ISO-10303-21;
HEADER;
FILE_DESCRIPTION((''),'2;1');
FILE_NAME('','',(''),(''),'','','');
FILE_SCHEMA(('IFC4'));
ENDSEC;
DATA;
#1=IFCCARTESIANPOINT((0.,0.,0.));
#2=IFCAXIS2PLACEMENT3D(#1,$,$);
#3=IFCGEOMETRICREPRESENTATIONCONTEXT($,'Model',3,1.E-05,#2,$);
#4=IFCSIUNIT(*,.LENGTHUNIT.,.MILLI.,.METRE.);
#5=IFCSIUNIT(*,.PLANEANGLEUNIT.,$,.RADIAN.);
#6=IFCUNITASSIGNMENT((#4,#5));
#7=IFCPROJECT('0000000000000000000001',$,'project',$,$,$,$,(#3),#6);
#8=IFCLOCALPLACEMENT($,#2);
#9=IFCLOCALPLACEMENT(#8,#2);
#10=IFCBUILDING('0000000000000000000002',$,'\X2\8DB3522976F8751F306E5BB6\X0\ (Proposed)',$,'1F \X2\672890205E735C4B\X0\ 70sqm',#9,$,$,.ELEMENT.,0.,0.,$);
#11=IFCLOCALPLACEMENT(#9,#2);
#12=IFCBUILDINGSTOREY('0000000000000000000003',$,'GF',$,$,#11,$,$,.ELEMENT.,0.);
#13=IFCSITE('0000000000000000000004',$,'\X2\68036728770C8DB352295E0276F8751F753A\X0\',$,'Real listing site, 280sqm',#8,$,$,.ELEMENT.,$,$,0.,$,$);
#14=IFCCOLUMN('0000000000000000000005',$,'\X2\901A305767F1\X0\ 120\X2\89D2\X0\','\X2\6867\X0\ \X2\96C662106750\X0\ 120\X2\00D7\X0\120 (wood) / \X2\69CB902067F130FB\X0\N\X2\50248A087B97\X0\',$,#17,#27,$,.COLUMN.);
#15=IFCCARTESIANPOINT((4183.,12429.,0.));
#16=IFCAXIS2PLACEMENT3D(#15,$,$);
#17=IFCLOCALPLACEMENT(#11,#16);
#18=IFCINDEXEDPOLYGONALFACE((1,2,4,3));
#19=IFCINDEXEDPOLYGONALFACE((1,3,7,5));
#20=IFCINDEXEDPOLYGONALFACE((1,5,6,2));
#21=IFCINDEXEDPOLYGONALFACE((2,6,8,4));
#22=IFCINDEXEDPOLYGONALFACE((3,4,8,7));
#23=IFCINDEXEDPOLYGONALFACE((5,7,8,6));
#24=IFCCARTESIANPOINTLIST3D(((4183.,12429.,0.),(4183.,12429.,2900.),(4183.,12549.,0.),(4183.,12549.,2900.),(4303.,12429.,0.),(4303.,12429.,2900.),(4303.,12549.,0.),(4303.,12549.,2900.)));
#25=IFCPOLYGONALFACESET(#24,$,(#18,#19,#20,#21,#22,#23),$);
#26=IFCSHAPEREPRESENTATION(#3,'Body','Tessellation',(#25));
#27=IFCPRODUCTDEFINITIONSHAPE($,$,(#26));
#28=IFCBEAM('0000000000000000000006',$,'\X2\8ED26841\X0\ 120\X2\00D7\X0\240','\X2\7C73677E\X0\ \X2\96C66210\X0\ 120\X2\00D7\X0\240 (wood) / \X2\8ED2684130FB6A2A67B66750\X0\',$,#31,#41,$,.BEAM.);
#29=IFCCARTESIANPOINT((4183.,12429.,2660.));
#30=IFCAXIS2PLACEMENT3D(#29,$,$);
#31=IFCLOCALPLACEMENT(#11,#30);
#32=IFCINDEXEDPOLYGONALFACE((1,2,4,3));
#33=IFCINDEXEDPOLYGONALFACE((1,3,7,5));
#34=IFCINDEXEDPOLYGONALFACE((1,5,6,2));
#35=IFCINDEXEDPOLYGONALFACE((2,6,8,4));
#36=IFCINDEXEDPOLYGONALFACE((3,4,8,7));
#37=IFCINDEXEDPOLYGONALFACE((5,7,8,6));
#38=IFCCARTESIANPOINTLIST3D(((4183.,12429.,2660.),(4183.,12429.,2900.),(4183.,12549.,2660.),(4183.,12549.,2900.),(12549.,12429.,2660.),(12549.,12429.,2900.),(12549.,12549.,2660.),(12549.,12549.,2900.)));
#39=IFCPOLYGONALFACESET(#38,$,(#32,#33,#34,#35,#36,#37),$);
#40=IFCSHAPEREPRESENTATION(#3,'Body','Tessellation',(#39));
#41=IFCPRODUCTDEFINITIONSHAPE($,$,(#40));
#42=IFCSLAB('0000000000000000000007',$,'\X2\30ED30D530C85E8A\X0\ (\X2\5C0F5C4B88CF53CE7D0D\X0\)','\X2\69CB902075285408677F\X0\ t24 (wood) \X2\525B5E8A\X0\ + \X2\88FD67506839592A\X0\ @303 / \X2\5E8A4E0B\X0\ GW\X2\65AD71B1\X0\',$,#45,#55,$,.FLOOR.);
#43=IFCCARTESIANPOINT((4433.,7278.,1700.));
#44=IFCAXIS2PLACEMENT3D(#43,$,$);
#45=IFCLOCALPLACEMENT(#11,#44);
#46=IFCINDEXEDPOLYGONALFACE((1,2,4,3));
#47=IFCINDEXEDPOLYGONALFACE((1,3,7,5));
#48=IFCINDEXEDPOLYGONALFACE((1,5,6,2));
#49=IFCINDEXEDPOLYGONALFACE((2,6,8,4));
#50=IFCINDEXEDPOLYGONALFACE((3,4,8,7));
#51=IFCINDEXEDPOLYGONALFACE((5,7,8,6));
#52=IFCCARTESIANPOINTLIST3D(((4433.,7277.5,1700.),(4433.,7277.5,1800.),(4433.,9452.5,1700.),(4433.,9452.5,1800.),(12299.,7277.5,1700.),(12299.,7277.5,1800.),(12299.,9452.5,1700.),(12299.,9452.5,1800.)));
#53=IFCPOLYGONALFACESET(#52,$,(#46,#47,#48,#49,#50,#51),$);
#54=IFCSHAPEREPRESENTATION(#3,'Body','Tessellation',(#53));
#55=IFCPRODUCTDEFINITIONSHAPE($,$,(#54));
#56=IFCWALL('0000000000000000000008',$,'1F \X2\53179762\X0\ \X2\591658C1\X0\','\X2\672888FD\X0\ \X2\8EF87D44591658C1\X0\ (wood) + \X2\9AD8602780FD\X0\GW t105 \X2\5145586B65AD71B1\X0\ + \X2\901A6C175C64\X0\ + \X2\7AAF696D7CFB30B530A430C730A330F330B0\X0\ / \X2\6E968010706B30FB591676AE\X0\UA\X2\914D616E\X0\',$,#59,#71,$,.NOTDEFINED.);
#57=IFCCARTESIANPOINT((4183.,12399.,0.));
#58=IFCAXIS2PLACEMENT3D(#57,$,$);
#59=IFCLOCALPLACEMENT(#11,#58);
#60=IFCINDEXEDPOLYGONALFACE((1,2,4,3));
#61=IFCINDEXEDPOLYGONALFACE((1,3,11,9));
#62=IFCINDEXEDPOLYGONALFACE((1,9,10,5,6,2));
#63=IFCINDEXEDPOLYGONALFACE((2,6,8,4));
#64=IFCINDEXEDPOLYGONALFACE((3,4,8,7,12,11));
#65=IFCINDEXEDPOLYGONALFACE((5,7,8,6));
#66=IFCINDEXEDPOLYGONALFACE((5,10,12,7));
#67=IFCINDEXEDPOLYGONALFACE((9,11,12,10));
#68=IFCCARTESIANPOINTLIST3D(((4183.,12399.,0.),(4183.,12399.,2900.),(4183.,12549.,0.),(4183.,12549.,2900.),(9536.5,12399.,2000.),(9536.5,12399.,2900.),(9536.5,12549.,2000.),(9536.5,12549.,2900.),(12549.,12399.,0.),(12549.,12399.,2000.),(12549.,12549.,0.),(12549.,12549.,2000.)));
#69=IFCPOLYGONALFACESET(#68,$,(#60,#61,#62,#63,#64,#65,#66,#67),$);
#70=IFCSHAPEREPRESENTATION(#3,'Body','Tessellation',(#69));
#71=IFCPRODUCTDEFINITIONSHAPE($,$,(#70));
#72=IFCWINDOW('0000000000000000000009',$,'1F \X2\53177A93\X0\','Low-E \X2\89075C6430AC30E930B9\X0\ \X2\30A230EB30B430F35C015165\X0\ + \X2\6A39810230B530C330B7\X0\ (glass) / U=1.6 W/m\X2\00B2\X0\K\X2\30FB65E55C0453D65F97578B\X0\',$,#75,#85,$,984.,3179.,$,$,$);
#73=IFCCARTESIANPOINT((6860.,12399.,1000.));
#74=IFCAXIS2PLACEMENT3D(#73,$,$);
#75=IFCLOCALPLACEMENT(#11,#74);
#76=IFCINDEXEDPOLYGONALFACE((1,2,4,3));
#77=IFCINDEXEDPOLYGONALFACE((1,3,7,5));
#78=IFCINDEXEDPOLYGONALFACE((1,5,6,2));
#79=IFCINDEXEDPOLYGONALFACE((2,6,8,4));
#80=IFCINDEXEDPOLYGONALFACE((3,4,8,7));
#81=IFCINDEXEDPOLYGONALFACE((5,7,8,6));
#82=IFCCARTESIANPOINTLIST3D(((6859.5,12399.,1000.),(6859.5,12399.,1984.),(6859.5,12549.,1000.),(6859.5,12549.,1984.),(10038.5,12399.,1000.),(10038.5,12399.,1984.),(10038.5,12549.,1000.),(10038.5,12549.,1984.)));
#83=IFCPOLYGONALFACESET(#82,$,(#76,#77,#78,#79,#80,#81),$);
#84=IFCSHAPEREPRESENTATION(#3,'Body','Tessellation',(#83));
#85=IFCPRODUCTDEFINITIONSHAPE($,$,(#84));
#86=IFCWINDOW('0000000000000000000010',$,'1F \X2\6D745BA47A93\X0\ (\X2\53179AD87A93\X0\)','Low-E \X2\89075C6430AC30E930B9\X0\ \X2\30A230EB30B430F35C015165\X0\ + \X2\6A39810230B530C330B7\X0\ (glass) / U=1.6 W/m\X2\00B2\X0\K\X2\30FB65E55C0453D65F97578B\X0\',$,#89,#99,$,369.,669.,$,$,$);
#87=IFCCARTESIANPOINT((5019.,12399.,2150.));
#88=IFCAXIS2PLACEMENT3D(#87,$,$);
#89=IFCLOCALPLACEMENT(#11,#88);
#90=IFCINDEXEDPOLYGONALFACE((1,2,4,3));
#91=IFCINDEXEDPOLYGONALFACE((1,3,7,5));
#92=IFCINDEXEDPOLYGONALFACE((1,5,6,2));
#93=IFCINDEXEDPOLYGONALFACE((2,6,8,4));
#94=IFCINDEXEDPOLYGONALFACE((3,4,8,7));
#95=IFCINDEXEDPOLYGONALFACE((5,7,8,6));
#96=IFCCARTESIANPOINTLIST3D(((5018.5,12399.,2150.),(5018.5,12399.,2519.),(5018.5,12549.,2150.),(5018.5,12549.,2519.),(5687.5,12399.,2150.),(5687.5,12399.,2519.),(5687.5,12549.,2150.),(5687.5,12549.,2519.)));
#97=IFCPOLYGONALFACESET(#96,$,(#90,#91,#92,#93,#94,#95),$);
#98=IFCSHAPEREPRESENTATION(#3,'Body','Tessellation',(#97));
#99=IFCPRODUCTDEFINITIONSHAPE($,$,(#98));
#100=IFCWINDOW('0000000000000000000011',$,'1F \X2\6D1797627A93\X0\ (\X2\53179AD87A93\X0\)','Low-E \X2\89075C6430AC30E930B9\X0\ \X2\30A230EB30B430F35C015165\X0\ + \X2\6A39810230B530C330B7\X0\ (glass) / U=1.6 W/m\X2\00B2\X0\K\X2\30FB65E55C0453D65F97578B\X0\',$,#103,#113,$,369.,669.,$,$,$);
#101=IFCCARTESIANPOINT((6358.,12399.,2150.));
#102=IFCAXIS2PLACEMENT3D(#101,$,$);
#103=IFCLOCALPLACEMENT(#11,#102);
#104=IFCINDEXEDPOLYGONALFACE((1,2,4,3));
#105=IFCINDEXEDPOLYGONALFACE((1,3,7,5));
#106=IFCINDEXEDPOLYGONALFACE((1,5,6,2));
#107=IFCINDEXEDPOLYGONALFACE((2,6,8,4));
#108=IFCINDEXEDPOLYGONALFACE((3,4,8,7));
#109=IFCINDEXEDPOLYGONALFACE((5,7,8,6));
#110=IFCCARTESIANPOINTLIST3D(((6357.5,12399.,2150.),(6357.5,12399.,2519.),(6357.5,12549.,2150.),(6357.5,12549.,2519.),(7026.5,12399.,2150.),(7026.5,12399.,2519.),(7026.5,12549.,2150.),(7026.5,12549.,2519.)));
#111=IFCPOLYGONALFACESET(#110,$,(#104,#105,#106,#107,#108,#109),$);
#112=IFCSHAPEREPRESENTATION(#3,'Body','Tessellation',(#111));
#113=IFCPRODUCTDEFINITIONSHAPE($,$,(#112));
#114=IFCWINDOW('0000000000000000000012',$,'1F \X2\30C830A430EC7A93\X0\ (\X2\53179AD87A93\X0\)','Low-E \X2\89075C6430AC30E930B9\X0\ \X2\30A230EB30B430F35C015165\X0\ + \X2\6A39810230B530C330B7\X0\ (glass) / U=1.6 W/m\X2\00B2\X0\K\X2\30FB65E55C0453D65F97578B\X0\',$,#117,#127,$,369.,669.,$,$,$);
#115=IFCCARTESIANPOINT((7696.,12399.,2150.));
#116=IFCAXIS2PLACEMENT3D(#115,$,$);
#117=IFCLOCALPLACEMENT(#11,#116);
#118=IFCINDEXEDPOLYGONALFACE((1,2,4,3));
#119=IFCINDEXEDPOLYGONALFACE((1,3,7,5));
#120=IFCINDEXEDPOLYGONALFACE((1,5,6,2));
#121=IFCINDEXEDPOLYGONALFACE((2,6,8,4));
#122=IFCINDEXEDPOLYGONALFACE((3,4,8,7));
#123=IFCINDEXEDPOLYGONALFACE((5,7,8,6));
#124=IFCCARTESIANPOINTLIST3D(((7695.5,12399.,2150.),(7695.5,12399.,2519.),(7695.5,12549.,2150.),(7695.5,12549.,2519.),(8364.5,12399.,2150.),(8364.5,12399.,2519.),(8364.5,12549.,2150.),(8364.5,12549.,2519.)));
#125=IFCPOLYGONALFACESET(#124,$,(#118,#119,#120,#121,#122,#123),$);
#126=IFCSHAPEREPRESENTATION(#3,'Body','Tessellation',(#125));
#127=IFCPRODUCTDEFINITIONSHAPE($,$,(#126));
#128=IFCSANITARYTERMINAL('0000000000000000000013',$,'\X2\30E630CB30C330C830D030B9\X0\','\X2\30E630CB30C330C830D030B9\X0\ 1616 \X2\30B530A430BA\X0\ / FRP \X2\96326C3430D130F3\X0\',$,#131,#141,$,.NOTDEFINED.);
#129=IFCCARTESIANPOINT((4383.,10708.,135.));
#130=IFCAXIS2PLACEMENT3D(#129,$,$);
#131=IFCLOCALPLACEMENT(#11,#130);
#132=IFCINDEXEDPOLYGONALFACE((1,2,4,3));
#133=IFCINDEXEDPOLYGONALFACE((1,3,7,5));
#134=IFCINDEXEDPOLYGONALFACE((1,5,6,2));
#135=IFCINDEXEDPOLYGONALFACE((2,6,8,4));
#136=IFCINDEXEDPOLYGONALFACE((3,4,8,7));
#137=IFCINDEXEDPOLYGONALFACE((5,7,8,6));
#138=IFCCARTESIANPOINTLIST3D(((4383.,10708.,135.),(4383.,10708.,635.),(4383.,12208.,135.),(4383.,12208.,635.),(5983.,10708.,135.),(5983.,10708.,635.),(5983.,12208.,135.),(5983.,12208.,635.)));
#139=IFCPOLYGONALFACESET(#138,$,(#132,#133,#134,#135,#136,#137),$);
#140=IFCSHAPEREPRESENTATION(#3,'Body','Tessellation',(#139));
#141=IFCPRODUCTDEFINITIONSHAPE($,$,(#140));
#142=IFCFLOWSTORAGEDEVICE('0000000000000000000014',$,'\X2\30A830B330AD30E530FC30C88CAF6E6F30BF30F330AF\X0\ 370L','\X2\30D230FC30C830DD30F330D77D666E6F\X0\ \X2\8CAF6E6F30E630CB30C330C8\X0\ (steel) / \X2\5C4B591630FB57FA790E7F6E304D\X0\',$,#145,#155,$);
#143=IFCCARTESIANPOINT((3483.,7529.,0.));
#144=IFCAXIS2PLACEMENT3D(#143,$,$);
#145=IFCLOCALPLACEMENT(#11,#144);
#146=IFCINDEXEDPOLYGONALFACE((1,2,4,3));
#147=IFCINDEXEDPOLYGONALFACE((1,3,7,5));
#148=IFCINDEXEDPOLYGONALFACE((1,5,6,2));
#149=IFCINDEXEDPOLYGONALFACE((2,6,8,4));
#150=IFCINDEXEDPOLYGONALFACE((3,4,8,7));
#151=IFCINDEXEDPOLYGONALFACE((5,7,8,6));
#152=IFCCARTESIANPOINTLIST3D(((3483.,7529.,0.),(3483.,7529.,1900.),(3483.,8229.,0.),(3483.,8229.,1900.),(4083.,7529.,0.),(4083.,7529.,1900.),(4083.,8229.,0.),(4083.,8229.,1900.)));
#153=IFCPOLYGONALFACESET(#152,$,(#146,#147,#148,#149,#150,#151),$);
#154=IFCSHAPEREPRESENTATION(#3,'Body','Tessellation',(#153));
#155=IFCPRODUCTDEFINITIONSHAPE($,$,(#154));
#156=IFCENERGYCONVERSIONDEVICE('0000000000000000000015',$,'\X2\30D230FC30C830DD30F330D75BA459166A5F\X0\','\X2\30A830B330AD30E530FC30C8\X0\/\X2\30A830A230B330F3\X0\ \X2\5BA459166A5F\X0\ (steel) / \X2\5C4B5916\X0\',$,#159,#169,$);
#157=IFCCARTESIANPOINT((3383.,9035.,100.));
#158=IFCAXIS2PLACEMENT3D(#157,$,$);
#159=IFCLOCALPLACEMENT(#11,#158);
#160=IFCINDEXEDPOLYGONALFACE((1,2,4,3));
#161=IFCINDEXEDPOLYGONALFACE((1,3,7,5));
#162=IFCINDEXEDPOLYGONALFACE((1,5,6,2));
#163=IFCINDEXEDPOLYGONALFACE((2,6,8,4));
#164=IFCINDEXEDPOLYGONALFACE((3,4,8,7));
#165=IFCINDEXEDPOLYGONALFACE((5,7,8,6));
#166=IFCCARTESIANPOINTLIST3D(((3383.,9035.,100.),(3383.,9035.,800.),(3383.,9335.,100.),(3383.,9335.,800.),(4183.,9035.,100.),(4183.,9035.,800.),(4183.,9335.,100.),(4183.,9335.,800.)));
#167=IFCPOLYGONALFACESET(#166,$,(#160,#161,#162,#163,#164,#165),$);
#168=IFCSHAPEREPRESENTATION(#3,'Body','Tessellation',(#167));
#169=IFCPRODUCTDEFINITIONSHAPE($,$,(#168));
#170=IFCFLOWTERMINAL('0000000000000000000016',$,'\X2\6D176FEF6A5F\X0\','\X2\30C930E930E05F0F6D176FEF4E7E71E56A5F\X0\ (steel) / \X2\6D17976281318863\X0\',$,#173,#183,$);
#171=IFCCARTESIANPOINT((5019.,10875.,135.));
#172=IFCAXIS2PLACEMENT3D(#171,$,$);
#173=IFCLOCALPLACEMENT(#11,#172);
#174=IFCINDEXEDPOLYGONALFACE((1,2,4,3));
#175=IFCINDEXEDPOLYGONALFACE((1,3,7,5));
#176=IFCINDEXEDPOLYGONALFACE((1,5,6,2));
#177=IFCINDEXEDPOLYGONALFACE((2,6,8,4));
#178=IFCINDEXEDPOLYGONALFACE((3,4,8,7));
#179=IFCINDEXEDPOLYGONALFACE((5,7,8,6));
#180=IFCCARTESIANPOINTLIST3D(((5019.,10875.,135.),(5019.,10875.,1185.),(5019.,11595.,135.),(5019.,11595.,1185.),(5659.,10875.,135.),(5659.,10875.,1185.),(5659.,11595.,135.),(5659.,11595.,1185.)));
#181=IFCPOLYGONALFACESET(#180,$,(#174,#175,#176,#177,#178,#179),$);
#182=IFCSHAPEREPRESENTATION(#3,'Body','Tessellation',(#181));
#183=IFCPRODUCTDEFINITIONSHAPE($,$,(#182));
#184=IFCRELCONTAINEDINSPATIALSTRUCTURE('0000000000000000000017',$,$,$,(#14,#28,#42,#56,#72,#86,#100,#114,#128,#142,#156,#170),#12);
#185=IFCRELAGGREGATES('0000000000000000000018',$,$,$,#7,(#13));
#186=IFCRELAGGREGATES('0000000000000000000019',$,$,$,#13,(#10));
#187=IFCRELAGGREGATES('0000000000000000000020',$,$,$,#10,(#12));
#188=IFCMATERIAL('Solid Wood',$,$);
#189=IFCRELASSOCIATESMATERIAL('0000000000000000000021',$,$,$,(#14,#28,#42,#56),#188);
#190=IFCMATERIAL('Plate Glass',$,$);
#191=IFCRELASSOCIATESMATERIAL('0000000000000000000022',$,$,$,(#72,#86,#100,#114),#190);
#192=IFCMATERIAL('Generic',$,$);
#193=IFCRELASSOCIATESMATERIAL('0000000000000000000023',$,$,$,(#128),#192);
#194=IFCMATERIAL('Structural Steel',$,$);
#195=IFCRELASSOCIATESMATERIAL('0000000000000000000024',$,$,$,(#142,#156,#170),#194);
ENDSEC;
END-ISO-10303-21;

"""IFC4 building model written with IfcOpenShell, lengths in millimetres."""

from ifc_helpers import new_model, si_unit, frame, frame_2d, origin, place, context, project, spatial, rectangle, extrude, material, element, fill, save


model = new_model("IFC4")

# Units and contexts
model_context = context("Model", 3, precision=1e-05, world=origin())
ifc_project = project(units=[si_unit("LENGTHUNIT", "METRE", prefix="MILLI"), si_unit("PLANEANGLEUNIT", "RADIAN")], contexts=[model_context])

# Site, building, storey
site_placement = place(None, origin())
site = spatial("IfcSite", under=ifc_project, at=site_placement, Name="栃木県足利市相生町", ObjectType="Real listing site, 280sqm", CompositionType="ELEMENT", RefElevation=0.0)
building_placement = place(site_placement, origin())
building = spatial("IfcBuilding", under=site, at=building_placement, Name="足利相生の家 (Proposed)", ObjectType="1F 木造平屋 70sqm", CompositionType="ELEMENT", ElevationOfRefHeight=0.0, ElevationOfTerrain=0.0)
storey_placement = place(building_placement, origin())
storey = spatial("IfcBuildingStorey", under=building, at=storey_placement, Name="GF", CompositionType="ELEMENT", Elevation=0.0)

# Column
ifc_material_1 = material(Name="Solid Wood")
column_1_placement = place(storey_placement, frame((4183.0, 12429.0, 0.0)))
element("IfcColumn", 1, at=column_1_placement, inside=storey, material=ifc_material_1, Name="通し柱 120角", Description="桧 集成材 120×120 (wood) / 構造柱・N値計算", PredefinedType="COLUMN", context=model_context, shape_type="SweptSolid", body=[
    extrude(rectangle(XDim=120.0, YDim=120.0, at=frame_2d((60.0, 60.0))), frame((4183.0, 12429.0, 0.0)), (0.0, 0.0, 1.0), 2900.0),
])

# Beam
beam_1_placement = place(storey_placement, frame((4183.0, 12429.0, 2660.0)))
element("IfcBeam", 2, at=beam_1_placement, inside=storey, material=ifc_material_1, Name="軒桁 120×240", Description="米松 集成 120×240 (wood) / 軒桁・横架材", PredefinedType="BEAM", context=model_context, shape_type="SweptSolid", body=[
    extrude(rectangle(XDim=8366.0, YDim=120.0, at=frame_2d((4183.0, 60.0))), frame((4183.0, 12429.0, 2660.0)), (0.0, 0.0, 1.0), 240.0),
])

# Slab
slab_placement = place(storey_placement, frame((4433.0, 7278.0, 1700.0)))
element("IfcSlab", 3, at=slab_placement, inside=storey, material=ifc_material_1, Name="ロフト床 (小屋裏収納)", Description="構造用合板 t24 (wood) 剛床 + 製材根太 @303 / 床下 GW断熱", PredefinedType="FLOOR", context=model_context, shape_type="SweptSolid", body=[
    extrude(rectangle(XDim=7866.0, YDim=2175.0, at=frame_2d((3933.0, 1087.0))), frame((4433.0, 7278.0, 1700.0)), (0.0, 0.0, 1.0), 100.0),
])

# Wall, openings, windows
wall_1_placement = place(storey_placement, frame((4183.0, 12399.0, 0.0)))
wall_1 = element("IfcWall", 4, at=wall_1_placement, inside=storey, material=ifc_material_1, Name="1F 北面 外壁", Description="木製 軸組外壁 (wood) + 高性能GW t105 充填断熱 + 通気層 + 窯業系サイディング / 準耐火・外皮UA配慮", PredefinedType="NOTDEFINED", context=model_context, shape_type="SweptSolid", body=[
    extrude(rectangle(XDim=8366.0, YDim=150.0, at=frame_2d((4183.0, 75.0))), frame((4183.0, 12399.0, 0.0)), (0.0, 0.0, 1.0), 2900.0),
])
opening_1_placement = place(storey_placement, frame((6860.0, 12399.0, 1000.0)))
opening_1 = element("IfcOpeningElement", 5, at=opening_1_placement, cuts=wall_1, PredefinedType="NOTDEFINED", context=model_context, shape_type="SweptSolid", body=[
    extrude(rectangle(XDim=3179.0, YDim=150.0, at=frame_2d((1589.0, 75.0))), frame((6860.0, 12399.0, 1000.0)), (0.0, 0.0, 1.0), 984.0),
])
opening_2_placement = place(storey_placement, frame((5019.0, 12399.0, 2150.0)))
opening_2 = element("IfcOpeningElement", 6, at=opening_2_placement, cuts=wall_1, PredefinedType="NOTDEFINED", context=model_context, shape_type="SweptSolid", body=[
    extrude(rectangle(XDim=669.0, YDim=150.0, at=frame_2d((334.0, 75.0))), frame((5019.0, 12399.0, 2150.0)), (0.0, 0.0, 1.0), 369.0),
])
opening_3_placement = place(storey_placement, frame((6358.0, 12399.0, 2150.0)))
opening_3 = element("IfcOpeningElement", 7, at=opening_3_placement, cuts=wall_1, PredefinedType="NOTDEFINED", context=model_context, shape_type="SweptSolid", body=[
    extrude(rectangle(XDim=669.0, YDim=150.0, at=frame_2d((334.0, 75.0))), frame((6358.0, 12399.0, 2150.0)), (0.0, 0.0, 1.0), 369.0),
])
opening_4_placement = place(storey_placement, frame((7696.0, 12399.0, 2150.0)))
opening_4 = element("IfcOpeningElement", 8, at=opening_4_placement, cuts=wall_1, PredefinedType="NOTDEFINED", context=model_context, shape_type="SweptSolid", body=[
    extrude(rectangle(XDim=669.0, YDim=150.0, at=frame_2d((334.0, 75.0))), frame((7696.0, 12399.0, 2150.0)), (0.0, 0.0, 1.0), 369.0),
])
ifc_material_2 = material(Name="Plate Glass")
window_1_placement = place(storey_placement, frame((6860.0, 12399.0, 1000.0)))
window_1 = element("IfcWindow", 9, at=window_1_placement, inside=storey, material=ifc_material_2, Name="1F 北窓", Description="Low-E 複層ガラス アルゴン封入 + 樹脂サッシ (glass) / U=1.6 W/m²K・日射取得型", OverallHeight=984.0, OverallWidth=3179.0, context=model_context, shape_type="SweptSolid", body=[
    extrude(rectangle(XDim=3179.0, YDim=150.0, at=frame_2d((1589.0, 75.0))), frame((6860.0, 12399.0, 1000.0)), (0.0, 0.0, 1.0), 984.0),
])
fill(opening_1, window_1)
window_2_placement = place(storey_placement, frame((5019.0, 12399.0, 2150.0)))
window_2 = element("IfcWindow", 10, at=window_2_placement, inside=storey, material=ifc_material_2, Name="1F 浴室窓 (北高窓)", Description="Low-E 複層ガラス アルゴン封入 + 樹脂サッシ (glass) / U=1.6 W/m²K・日射取得型", OverallHeight=369.0, OverallWidth=669.0, context=model_context, shape_type="SweptSolid", body=[
    extrude(rectangle(XDim=669.0, YDim=150.0, at=frame_2d((334.0, 75.0))), frame((5019.0, 12399.0, 2150.0)), (0.0, 0.0, 1.0), 369.0),
])
fill(opening_2, window_2)
window_3_placement = place(storey_placement, frame((6358.0, 12399.0, 2150.0)))
window_3 = element("IfcWindow", 11, at=window_3_placement, inside=storey, material=ifc_material_2, Name="1F 洗面窓 (北高窓)", Description="Low-E 複層ガラス アルゴン封入 + 樹脂サッシ (glass) / U=1.6 W/m²K・日射取得型", OverallHeight=369.0, OverallWidth=669.0, context=model_context, shape_type="SweptSolid", body=[
    extrude(rectangle(XDim=669.0, YDim=150.0, at=frame_2d((334.0, 75.0))), frame((6358.0, 12399.0, 2150.0)), (0.0, 0.0, 1.0), 369.0),
])
fill(opening_3, window_3)
window_4_placement = place(storey_placement, frame((7696.0, 12399.0, 2150.0)))
window_4 = element("IfcWindow", 12, at=window_4_placement, inside=storey, material=ifc_material_2, Name="1F トイレ窓 (北高窓)", Description="Low-E 複層ガラス アルゴン封入 + 樹脂サッシ (glass) / U=1.6 W/m²K・日射取得型", OverallHeight=369.0, OverallWidth=669.0, context=model_context, shape_type="SweptSolid", body=[
    extrude(rectangle(XDim=669.0, YDim=150.0, at=frame_2d((334.0, 75.0))), frame((7696.0, 12399.0, 2150.0)), (0.0, 0.0, 1.0), 369.0),
])
fill(opening_4, window_4)

# Sanitary terminal
ifc_material_3 = material(Name="Generic")
sanitary_terminal_placement = place(storey_placement, frame((4383.0, 10708.0, 135.0)))
element("IfcSanitaryTerminal", 13, at=sanitary_terminal_placement, inside=storey, material=ifc_material_3, Name="ユニットバス", Description="ユニットバス 1616 サイズ / FRP 防水パン", PredefinedType="NOTDEFINED", context=model_context, shape_type="SweptSolid", body=[
    extrude(rectangle(XDim=1600.0, YDim=1500.0, at=frame_2d((800.0, 750.0))), frame((4383.0, 10708.0, 135.0)), (0.0, 0.0, 1.0), 500.0),
])

# Flow storage device
ifc_material_4 = material(Name="Structural Steel")
flow_storage_device_placement = place(storey_placement, frame((3483.0, 7529.0, 0.0)))
element("IfcFlowStorageDevice", 14, at=flow_storage_device_placement, inside=storey, material=ifc_material_4, Name="エコキュート貯湯タンク 370L", Description="ヒートポンプ給湯 貯湯ユニット (steel) / 屋外・基礎置き", context=model_context, shape_type="SweptSolid", body=[
    extrude(rectangle(XDim=600.0, YDim=700.0, at=frame_2d((300.0, 350.0))), frame((3483.0, 7529.0, 0.0)), (0.0, 0.0, 1.0), 1900.0),
])

# Energy conversion device
energy_conversion_device_placement = place(storey_placement, frame((3383.0, 9035.0, 100.0)))
element("IfcEnergyConversionDevice", 15, at=energy_conversion_device_placement, inside=storey, material=ifc_material_4, Name="ヒートポンプ室外機", Description="エコキュート/エアコン 室外機 (steel) / 屋外", context=model_context, shape_type="SweptSolid", body=[
    extrude(rectangle(XDim=800.0, YDim=300.0, at=frame_2d((400.0, 150.0))), frame((3383.0, 9035.0, 100.0)), (0.0, 0.0, 1.0), 700.0),
])

# Flow terminal
flow_terminal_placement = place(storey_placement, frame((5019.0, 10875.0, 135.0)))
element("IfcFlowTerminal", 16, at=flow_terminal_placement, inside=storey, material=ifc_material_4, Name="洗濯機", Description="ドラム式洗濯乾燥機 (steel) / 洗面脱衣", context=model_context, shape_type="SweptSolid", body=[
    extrude(rectangle(XDim=640.0, YDim=720.0, at=frame_2d((320.0, 360.0))), frame((5019.0, 10875.0, 135.0)), (0.0, 0.0, 1.0), 1050.0),
])

save(model, "model.ifc")
